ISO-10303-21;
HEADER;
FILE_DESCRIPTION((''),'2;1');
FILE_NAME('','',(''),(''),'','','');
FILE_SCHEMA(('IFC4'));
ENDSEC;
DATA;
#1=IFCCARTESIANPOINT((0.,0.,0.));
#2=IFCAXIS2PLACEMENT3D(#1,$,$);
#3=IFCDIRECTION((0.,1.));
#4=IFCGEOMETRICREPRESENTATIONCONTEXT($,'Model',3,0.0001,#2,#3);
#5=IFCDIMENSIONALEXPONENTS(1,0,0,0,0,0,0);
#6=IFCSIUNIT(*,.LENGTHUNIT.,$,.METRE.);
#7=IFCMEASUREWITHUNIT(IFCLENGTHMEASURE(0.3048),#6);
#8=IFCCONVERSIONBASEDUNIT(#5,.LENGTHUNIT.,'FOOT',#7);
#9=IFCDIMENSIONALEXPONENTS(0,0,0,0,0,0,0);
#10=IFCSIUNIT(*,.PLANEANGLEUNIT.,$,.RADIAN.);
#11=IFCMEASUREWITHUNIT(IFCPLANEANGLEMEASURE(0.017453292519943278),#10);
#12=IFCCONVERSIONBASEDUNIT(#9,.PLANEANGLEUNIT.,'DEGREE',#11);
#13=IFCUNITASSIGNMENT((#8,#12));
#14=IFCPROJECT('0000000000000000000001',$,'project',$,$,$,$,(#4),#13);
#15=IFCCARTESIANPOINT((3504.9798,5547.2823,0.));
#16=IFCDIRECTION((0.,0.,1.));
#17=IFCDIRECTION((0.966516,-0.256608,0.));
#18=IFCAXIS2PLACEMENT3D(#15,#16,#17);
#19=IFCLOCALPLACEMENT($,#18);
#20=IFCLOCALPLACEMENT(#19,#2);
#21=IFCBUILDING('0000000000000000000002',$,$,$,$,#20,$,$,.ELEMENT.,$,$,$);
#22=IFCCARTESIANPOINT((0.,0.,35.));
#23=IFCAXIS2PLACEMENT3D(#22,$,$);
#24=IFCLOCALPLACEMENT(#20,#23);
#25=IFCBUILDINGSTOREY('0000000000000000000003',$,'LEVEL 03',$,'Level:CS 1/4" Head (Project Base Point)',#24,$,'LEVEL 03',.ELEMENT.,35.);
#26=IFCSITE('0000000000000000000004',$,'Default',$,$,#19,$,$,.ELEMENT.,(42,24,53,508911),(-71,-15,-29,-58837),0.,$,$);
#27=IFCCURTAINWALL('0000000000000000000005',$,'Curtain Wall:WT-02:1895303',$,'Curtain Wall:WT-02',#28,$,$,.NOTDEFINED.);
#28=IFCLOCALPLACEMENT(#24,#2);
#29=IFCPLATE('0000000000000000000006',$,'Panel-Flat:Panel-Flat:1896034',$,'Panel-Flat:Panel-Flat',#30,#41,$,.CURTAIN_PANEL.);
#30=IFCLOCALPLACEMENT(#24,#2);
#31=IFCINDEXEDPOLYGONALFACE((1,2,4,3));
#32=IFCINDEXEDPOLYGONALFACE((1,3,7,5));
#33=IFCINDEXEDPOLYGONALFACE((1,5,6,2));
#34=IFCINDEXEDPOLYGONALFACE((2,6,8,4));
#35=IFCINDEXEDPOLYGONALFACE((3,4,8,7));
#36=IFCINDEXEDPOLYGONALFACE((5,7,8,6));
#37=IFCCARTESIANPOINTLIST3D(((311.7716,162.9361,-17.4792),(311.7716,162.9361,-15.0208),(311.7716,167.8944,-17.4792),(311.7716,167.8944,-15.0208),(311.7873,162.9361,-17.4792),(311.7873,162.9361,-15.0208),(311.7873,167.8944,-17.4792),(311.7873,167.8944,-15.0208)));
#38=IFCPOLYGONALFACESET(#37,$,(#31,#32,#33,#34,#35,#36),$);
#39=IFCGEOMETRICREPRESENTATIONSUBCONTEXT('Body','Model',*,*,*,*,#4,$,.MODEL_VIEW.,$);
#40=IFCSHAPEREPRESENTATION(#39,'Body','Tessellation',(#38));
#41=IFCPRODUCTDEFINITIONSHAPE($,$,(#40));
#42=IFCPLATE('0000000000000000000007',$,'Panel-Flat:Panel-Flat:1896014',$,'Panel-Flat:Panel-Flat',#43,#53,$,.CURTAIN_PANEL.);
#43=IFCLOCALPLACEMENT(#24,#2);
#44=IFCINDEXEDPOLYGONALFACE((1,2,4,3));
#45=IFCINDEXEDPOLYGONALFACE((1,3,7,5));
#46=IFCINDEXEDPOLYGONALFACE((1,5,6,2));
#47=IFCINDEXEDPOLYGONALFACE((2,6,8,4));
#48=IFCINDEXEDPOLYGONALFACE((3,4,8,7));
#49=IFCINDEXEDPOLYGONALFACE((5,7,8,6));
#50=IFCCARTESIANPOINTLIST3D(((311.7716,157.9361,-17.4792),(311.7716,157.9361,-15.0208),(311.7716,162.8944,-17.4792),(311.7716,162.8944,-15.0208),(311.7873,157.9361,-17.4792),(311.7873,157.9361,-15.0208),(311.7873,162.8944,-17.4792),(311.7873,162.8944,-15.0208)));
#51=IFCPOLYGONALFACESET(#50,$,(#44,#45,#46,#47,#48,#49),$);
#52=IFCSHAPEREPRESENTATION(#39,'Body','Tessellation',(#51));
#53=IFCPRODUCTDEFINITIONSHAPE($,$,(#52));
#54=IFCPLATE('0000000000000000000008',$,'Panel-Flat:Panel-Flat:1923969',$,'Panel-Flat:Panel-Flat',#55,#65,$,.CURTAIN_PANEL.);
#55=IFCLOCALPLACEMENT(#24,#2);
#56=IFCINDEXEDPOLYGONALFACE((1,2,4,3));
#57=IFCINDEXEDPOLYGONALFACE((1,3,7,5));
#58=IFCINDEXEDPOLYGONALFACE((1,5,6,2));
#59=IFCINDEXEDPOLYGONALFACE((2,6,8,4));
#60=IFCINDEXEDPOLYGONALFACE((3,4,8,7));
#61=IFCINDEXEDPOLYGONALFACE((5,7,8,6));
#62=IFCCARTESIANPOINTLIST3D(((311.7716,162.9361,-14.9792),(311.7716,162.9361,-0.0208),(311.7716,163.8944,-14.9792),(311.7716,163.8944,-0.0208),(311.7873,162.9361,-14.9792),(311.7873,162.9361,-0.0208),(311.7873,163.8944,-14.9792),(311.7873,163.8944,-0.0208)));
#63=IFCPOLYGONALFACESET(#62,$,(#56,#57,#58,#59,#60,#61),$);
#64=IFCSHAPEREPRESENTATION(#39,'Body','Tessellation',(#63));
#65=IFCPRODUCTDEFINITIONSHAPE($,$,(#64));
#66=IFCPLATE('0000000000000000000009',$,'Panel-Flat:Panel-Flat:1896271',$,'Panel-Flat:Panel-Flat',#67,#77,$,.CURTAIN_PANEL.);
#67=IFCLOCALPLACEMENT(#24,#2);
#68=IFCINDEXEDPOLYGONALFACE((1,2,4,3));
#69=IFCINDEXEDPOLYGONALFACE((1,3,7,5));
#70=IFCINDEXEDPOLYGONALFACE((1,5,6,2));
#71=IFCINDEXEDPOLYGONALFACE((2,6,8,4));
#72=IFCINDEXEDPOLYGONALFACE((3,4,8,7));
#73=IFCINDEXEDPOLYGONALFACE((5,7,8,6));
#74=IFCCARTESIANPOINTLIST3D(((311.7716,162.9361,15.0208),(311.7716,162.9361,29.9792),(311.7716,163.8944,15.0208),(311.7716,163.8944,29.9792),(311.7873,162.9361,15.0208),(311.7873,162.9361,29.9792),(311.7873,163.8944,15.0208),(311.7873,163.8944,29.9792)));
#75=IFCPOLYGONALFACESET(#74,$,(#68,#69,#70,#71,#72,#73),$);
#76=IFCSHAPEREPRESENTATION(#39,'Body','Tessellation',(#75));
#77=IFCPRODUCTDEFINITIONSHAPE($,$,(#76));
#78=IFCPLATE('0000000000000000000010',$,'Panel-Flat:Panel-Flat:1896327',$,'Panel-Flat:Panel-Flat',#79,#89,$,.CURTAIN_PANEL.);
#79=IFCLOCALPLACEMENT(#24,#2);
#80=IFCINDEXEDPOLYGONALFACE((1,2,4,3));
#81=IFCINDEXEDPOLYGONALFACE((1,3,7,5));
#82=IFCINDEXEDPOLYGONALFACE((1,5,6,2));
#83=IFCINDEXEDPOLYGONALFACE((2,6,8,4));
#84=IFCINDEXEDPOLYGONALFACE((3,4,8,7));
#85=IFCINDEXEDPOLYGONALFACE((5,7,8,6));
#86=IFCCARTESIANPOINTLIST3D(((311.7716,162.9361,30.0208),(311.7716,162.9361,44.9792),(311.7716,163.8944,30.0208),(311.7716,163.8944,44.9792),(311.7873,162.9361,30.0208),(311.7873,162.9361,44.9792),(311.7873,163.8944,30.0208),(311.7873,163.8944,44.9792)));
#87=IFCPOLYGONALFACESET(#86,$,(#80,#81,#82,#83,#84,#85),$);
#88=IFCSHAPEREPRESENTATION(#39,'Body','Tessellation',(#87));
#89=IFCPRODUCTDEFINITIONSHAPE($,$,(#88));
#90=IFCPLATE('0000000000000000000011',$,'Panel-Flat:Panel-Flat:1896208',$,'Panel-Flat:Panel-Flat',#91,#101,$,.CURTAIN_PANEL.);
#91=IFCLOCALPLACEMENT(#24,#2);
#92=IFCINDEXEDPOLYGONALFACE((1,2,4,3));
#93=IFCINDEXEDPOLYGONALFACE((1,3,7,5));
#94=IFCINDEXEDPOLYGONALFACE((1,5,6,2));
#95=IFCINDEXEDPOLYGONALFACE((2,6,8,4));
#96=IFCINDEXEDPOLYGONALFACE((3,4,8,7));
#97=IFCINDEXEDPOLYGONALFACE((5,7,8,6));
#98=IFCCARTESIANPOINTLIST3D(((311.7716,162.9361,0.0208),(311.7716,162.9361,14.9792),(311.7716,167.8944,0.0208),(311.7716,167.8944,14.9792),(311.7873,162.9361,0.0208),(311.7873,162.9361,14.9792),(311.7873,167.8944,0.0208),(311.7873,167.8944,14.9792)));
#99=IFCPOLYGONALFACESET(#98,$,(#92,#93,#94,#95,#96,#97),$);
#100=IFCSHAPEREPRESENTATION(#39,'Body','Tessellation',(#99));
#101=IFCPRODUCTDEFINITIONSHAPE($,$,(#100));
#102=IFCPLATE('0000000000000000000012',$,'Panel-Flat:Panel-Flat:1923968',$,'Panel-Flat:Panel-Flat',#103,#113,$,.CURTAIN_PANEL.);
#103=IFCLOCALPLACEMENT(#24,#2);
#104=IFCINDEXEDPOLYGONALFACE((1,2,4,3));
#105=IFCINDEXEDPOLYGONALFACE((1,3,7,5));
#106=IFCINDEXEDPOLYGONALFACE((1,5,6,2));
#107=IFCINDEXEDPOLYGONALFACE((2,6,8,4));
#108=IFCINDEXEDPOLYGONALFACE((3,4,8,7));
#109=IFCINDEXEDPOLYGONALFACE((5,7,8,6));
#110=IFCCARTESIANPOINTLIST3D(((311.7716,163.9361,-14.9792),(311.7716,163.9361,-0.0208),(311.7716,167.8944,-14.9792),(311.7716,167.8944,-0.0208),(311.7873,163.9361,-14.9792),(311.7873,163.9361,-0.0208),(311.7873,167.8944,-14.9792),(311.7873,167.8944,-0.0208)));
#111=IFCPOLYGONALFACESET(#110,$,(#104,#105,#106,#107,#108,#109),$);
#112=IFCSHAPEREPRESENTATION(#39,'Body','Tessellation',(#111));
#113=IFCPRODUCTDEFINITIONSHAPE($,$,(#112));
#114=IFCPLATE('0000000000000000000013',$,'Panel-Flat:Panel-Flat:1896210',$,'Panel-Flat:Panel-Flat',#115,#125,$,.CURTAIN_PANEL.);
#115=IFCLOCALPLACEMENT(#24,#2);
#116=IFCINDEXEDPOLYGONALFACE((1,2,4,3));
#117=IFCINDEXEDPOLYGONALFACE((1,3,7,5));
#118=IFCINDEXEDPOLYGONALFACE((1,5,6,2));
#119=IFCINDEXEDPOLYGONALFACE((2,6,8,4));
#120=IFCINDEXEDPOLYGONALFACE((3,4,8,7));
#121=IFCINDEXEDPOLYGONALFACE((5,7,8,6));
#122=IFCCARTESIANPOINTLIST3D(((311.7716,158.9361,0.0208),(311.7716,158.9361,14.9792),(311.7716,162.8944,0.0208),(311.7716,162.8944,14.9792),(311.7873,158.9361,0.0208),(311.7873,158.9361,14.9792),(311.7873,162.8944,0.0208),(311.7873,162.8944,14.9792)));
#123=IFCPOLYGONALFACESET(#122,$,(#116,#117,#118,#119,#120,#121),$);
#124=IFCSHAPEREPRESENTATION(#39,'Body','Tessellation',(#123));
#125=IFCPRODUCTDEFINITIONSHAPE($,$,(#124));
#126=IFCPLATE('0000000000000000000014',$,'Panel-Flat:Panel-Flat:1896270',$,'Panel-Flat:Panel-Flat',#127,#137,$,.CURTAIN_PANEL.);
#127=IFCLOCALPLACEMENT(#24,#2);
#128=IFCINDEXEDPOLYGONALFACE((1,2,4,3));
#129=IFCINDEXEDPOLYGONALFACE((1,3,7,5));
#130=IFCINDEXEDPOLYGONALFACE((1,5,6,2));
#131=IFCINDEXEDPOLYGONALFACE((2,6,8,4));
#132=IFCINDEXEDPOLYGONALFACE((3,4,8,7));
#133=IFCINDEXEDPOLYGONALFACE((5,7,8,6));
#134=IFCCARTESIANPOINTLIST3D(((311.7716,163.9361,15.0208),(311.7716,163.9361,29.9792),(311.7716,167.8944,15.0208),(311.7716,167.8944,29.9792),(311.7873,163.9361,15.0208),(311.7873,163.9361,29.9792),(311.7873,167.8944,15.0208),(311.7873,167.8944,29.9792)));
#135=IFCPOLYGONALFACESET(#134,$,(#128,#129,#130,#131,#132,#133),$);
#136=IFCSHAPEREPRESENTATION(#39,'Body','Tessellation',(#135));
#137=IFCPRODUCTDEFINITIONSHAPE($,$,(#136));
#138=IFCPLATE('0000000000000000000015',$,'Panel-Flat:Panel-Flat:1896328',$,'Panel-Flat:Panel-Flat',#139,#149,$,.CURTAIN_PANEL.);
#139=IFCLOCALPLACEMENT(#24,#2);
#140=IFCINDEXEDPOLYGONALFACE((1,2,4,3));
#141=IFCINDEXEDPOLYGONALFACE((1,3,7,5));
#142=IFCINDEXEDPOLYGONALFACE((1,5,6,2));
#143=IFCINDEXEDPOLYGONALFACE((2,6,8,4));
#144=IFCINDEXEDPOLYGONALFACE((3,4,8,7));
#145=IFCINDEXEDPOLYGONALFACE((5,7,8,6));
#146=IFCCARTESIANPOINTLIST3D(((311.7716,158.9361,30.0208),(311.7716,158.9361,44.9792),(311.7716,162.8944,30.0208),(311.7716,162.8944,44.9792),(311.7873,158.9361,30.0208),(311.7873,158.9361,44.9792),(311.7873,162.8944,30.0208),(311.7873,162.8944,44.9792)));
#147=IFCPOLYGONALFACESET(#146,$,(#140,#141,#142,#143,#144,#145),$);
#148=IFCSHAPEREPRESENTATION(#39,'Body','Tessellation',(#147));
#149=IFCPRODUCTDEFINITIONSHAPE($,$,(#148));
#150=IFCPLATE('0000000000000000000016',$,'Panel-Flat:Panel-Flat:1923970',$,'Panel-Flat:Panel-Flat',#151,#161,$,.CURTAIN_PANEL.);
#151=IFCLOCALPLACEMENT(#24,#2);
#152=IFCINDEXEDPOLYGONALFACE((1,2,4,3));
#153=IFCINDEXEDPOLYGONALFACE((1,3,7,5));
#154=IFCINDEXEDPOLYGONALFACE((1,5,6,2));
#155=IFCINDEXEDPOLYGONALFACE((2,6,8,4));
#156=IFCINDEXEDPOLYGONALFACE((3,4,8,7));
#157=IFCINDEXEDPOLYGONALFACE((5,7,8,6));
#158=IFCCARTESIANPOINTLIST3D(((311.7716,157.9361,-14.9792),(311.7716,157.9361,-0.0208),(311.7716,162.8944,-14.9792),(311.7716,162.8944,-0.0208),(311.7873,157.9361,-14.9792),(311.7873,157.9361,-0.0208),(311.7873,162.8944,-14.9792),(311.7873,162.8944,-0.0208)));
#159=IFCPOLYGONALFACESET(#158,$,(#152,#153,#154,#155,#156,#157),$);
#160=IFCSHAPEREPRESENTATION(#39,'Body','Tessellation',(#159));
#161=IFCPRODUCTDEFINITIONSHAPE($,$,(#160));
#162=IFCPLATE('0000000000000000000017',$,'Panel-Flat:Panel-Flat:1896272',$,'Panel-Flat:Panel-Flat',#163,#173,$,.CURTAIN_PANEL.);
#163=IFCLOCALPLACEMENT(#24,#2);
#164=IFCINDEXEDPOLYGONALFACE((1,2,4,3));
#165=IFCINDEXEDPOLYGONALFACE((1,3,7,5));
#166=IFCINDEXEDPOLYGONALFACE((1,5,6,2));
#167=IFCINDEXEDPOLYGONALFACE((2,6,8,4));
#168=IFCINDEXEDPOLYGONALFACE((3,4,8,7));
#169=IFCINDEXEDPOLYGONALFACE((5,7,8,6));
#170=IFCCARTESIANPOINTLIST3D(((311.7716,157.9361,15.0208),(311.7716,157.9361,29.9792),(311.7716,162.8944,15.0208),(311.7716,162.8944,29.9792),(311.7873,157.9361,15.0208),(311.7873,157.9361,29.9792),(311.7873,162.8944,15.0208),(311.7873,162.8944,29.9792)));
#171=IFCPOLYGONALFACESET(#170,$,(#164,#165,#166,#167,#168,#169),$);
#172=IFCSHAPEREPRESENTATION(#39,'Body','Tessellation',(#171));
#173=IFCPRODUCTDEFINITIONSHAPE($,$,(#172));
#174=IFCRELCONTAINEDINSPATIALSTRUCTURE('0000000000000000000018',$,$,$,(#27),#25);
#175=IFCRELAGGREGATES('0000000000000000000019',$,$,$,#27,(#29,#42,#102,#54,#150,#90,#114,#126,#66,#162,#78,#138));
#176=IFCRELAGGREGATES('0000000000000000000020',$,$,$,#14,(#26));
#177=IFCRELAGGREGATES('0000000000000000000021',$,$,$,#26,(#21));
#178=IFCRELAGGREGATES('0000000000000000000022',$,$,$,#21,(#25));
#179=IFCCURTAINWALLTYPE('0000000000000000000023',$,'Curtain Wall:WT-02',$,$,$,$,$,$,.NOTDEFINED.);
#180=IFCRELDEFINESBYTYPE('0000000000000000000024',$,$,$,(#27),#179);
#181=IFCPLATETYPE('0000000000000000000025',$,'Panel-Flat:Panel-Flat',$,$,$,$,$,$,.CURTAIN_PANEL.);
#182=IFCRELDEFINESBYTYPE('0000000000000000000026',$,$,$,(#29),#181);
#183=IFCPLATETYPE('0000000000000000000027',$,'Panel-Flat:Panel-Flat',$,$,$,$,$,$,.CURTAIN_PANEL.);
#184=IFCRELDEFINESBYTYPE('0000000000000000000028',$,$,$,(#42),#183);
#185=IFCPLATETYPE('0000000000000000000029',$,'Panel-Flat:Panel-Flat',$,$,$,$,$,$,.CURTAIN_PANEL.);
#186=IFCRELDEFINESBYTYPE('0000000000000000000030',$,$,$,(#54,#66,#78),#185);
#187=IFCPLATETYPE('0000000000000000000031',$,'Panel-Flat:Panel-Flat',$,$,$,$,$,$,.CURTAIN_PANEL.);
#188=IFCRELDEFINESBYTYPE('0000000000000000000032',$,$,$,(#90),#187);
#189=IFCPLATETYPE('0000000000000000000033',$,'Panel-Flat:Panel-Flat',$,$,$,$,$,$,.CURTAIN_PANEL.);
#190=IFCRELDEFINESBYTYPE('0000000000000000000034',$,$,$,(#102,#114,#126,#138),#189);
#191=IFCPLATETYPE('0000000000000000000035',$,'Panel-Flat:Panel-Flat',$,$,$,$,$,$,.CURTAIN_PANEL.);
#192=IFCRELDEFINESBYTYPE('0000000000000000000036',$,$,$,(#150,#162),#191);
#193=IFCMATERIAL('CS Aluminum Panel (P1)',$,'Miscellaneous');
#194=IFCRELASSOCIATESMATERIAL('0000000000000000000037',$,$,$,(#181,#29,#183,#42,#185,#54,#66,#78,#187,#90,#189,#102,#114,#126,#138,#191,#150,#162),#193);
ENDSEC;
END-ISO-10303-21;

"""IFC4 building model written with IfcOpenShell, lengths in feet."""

from ifc_helpers import new_model, entity, si_unit, converted_unit, direction, frame, origin, place, context, subcontext, project, spatial, indexed_curve, outline, extrude, source, transform, mapped, material, type_object, type_shapes, element, aggregate, save


model = new_model("IFC4")

# Units and contexts
model_context = context("Model", 3, precision=0.0001, world=origin(), true_north=direction((0.0, 1.0)))
body_context = subcontext(model_context, "Body", "Model", "MODEL_VIEW")
ifc_project = project(units=[converted_unit("LENGTHUNIT", "FOOT", entity("IfcLengthMeasure", 0.3048), si_unit("LENGTHUNIT", "METRE"), dimensions=[1, 0, 0, 0, 0, 0, 0]), converted_unit("PLANEANGLEUNIT", "DEGREE", entity("IfcPlaneAngleMeasure", 0.017453292519943278), si_unit("PLANEANGLEUNIT", "RADIAN"), dimensions=[0, 0, 0, 0, 0, 0, 0])], contexts=[model_context])

# Site, building, storey
site_placement = place(None, frame((3504.9798, 5547.2823, 0.0), z_axis=(0.0, 0.0, 1.0), x_axis=(0.966516, -0.256608, 0.0)))
site = spatial("IfcSite", under=ifc_project, at=site_placement, Name="Default", CompositionType="ELEMENT", RefLatitude=(42, 24, 53, 508911), RefLongitude=(-71, -15, -29, -58837), RefElevation=0.0)
building_placement = place(site_placement, origin())
building = spatial("IfcBuilding", under=site, at=building_placement, CompositionType="ELEMENT")
storey_placement = place(building_placement, frame((0.0, 0.0, 35.0)))
storey = spatial("IfcBuildingStorey", under=building, at=storey_placement, Name="LEVEL 03", ObjectType="Level:CS 1/4\" Head (Project Base Point)", LongName="LEVEL 03", CompositionType="ELEMENT", Elevation=35.0)

# Curtain wall, plates
curtain_wall_type = type_object("IfcCurtainWallType", Name="Curtain Wall:WT-02", PredefinedType="NOTDEFINED")
curtain_wall_placement = place(storey_placement, frame((0.0, 0.0, -35.0)))
curtain_wall = element("IfcCurtainWall", 1, at=curtain_wall_placement, inside=storey, type_object=curtain_wall_type, Name="Curtain Wall:WT-02:1895303", ObjectType="Curtain Wall:WT-02", PredefinedType="NOTDEFINED")
ifc_material_1 = material(Name="CS Aluminum Panel (P1)", Category="Miscellaneous")
plate_type_1 = type_object("IfcPlateType", Name="Panel-Flat:Panel-Flat", PredefinedType="CURTAIN_PANEL", material=ifc_material_1)
shared_shape_1 = source(origin(), body_context, "Body", "SweptSolid", [
    extrude(outline(indexed_curve([(-0.0078, -2.4792), (0.0078, -2.4792), (0.0078, 2.4792), (-0.0078, 2.4792), (-0.0078, -2.4792)], self_intersect=False)), frame((0.0, -0.0078, 0.0208), z_axis=(0.0, 0.0, 1.0), x_axis=(0.0, -1.0, 0.0)), (0.0, 0.0, 1.0), 2.4583),
])
type_shapes(plate_type_1, [shared_shape_1])
plate_1_placement = place(curtain_wall_placement, frame((311.7873, 165.4153, 17.5), z_axis=(0.0, 0.0, 1.0), x_axis=(0.0, -1.0, 0.0)))
plate_1 = element("IfcPlate", 2, at=plate_1_placement, type_object=plate_type_1, material=ifc_material_1, Name="Panel-Flat:Panel-Flat:1896034", ObjectType="Panel-Flat:Panel-Flat", PredefinedType="CURTAIN_PANEL", context=body_context, shape_type="MappedRepresentation", body=[
    mapped(shared_shape_1, transform((0.0, 0.0, 0.0), scale=1.0)),
])
plate_type_2 = type_object("IfcPlateType", Name="Panel-Flat:Panel-Flat", PredefinedType="CURTAIN_PANEL", material=ifc_material_1)
shared_shape_2 = source(origin(), body_context, "Body", "SweptSolid", [
    extrude(outline(indexed_curve([(-0.0078, -2.4792), (0.0078, -2.4792), (0.0078, 2.4792), (-0.0078, 2.4792), (-0.0078, -2.4792)], self_intersect=False)), frame((0.0, -0.0078, 0.0208), z_axis=(0.0, 0.0, 1.0), x_axis=(0.0, -1.0, 0.0)), (0.0, 0.0, 1.0), 2.4583),
])
type_shapes(plate_type_2, [shared_shape_2])
plate_2_placement = place(curtain_wall_placement, frame((311.7873, 160.4153, 17.5), z_axis=(0.0, 0.0, 1.0), x_axis=(0.0, -1.0, 0.0)))
plate_2 = element("IfcPlate", 3, at=plate_2_placement, type_object=plate_type_2, material=ifc_material_1, Name="Panel-Flat:Panel-Flat:1896014", ObjectType="Panel-Flat:Panel-Flat", PredefinedType="CURTAIN_PANEL", context=body_context, shape_type="MappedRepresentation", body=[
    mapped(shared_shape_2, transform((0.0, 0.0, 0.0), scale=1.0)),
])
plate_type_3 = type_object("IfcPlateType", Name="Panel-Flat:Panel-Flat", PredefinedType="CURTAIN_PANEL", material=ifc_material_1)
shared_shape_3 = source(origin(), body_context, "Body", "SweptSolid", [
    extrude(outline(indexed_curve([(-0.0078, -0.4792), (0.0078, -0.4792), (0.0078, 0.4792), (-0.0078, 0.4792), (-0.0078, -0.4792)], self_intersect=False)), frame((0.0, -0.0078, 0.0208), z_axis=(0.0, 0.0, 1.0), x_axis=(0.0, -1.0, 0.0)), (0.0, 0.0, 1.0), 14.9583),
])
type_shapes(plate_type_3, [shared_shape_3])
plate_3_placement = place(curtain_wall_placement, frame((311.7873, 163.4153, 20.0), z_axis=(0.0, 0.0, 1.0), x_axis=(0.0, -1.0, 0.0)))
plate_3 = element("IfcPlate", 4, at=plate_3_placement, type_object=plate_type_3, material=ifc_material_1, Name="Panel-Flat:Panel-Flat:1923969", ObjectType="Panel-Flat:Panel-Flat", PredefinedType="CURTAIN_PANEL", context=body_context, shape_type="MappedRepresentation", body=[
    mapped(shared_shape_3, transform((0.0, 0.0, 0.0), scale=1.0)),
])
plate_4_placement = place(curtain_wall_placement, frame((311.7873, 163.4153, 50.0), z_axis=(0.0, 0.0, 1.0), x_axis=(0.0, -1.0, 0.0)))
plate_4 = element("IfcPlate", 5, at=plate_4_placement, type_object=plate_type_3, material=ifc_material_1, Name="Panel-Flat:Panel-Flat:1896271", ObjectType="Panel-Flat:Panel-Flat", PredefinedType="CURTAIN_PANEL", context=body_context, shape_type="MappedRepresentation", body=[
    mapped(shared_shape_3, transform((0.0, 0.0, 0.0), scale=1.0)),
])
plate_5_placement = place(curtain_wall_placement, frame((311.7873, 163.4153, 65.0), z_axis=(0.0, 0.0, 1.0), x_axis=(0.0, -1.0, 0.0)))
plate_5 = element("IfcPlate", 6, at=plate_5_placement, type_object=plate_type_3, material=ifc_material_1, Name="Panel-Flat:Panel-Flat:1896327", ObjectType="Panel-Flat:Panel-Flat", PredefinedType="CURTAIN_PANEL", context=body_context, shape_type="MappedRepresentation", body=[
    mapped(shared_shape_3, transform((0.0, 0.0, 0.0), scale=1.0)),
])
plate_type_4 = type_object("IfcPlateType", Name="Panel-Flat:Panel-Flat", PredefinedType="CURTAIN_PANEL", material=ifc_material_1)
shared_shape_4 = source(origin(), body_context, "Body", "SweptSolid", [
    extrude(outline(indexed_curve([(-0.0078, -2.4792), (0.0078, -2.4792), (0.0078, 2.4792), (-0.0078, 2.4792), (-0.0078, -2.4792)], self_intersect=False)), frame((0.0, -0.0078, 0.0208), z_axis=(0.0, 0.0, 1.0), x_axis=(0.0, -1.0, 0.0)), (0.0, 0.0, 1.0), 14.9583),
])
type_shapes(plate_type_4, [shared_shape_4])
plate_6_placement = place(curtain_wall_placement, frame((311.7873, 165.4153, 35.0), z_axis=(0.0, 0.0, 1.0), x_axis=(0.0, -1.0, 0.0)))
plate_6 = element("IfcPlate", 7, at=plate_6_placement, type_object=plate_type_4, material=ifc_material_1, Name="Panel-Flat:Panel-Flat:1896208", ObjectType="Panel-Flat:Panel-Flat", PredefinedType="CURTAIN_PANEL", context=body_context, shape_type="MappedRepresentation", body=[
    mapped(shared_shape_4, transform((0.0, 0.0, 0.0), scale=1.0)),
])
plate_type_5 = type_object("IfcPlateType", Name="Panel-Flat:Panel-Flat", PredefinedType="CURTAIN_PANEL", material=ifc_material_1)
shared_shape_5 = source(origin(), body_context, "Body", "SweptSolid", [
    extrude(outline(indexed_curve([(-0.0078, -1.9792), (0.0078, -1.9792), (0.0078, 1.9792), (-0.0078, 1.9792), (-0.0078, -1.9792)], self_intersect=False)), frame((0.0, -0.0078, 0.0208), z_axis=(0.0, 0.0, 1.0), x_axis=(0.0, -1.0, 0.0)), (0.0, 0.0, 1.0), 14.9583),
])
type_shapes(plate_type_5, [shared_shape_5])
plate_7_placement = place(curtain_wall_placement, frame((311.7873, 165.9153, 20.0), z_axis=(0.0, 0.0, 1.0), x_axis=(0.0, -1.0, 0.0)))
plate_7 = element("IfcPlate", 8, at=plate_7_placement, type_object=plate_type_5, material=ifc_material_1, Name="Panel-Flat:Panel-Flat:1923968", ObjectType="Panel-Flat:Panel-Flat", PredefinedType="CURTAIN_PANEL", context=body_context, shape_type="MappedRepresentation", body=[
    mapped(shared_shape_5, transform((0.0, 0.0, 0.0), scale=1.0)),
])
plate_8_placement = place(curtain_wall_placement, frame((311.7873, 160.9153, 35.0), z_axis=(0.0, 0.0, 1.0), x_axis=(0.0, -1.0, 0.0)))
plate_8 = element("IfcPlate", 9, at=plate_8_placement, type_object=plate_type_5, material=ifc_material_1, Name="Panel-Flat:Panel-Flat:1896210", ObjectType="Panel-Flat:Panel-Flat", PredefinedType="CURTAIN_PANEL", context=body_context, shape_type="MappedRepresentation", body=[
    mapped(shared_shape_5, transform((0.0, 0.0, 0.0), scale=1.0)),
])
plate_9_placement = place(curtain_wall_placement, frame((311.7873, 165.9153, 50.0), z_axis=(0.0, 0.0, 1.0), x_axis=(0.0, -1.0, 0.0)))
plate_9 = element("IfcPlate", 10, at=plate_9_placement, type_object=plate_type_5, material=ifc_material_1, Name="Panel-Flat:Panel-Flat:1896270", ObjectType="Panel-Flat:Panel-Flat", PredefinedType="CURTAIN_PANEL", context=body_context, shape_type="MappedRepresentation", body=[
    mapped(shared_shape_5, transform((0.0, 0.0, 0.0), scale=1.0)),
])
plate_10_placement = place(curtain_wall_placement, frame((311.7873, 160.9153, 65.0), z_axis=(0.0, 0.0, 1.0), x_axis=(0.0, -1.0, 0.0)))
plate_10 = element("IfcPlate", 11, at=plate_10_placement, type_object=plate_type_5, material=ifc_material_1, Name="Panel-Flat:Panel-Flat:1896328", ObjectType="Panel-Flat:Panel-Flat", PredefinedType="CURTAIN_PANEL", context=body_context, shape_type="MappedRepresentation", body=[
    mapped(shared_shape_5, transform((0.0, 0.0, 0.0), scale=1.0)),
])
plate_type_6 = type_object("IfcPlateType", Name="Panel-Flat:Panel-Flat", PredefinedType="CURTAIN_PANEL", material=ifc_material_1)
shared_shape_6 = source(origin(), body_context, "Body", "SweptSolid", [
    extrude(outline(indexed_curve([(-0.0078, -2.4792), (0.0078, -2.4792), (0.0078, 2.4792), (-0.0078, 2.4792), (-0.0078, -2.4792)], self_intersect=False)), frame((0.0, -0.0078, 0.0208), z_axis=(0.0, 0.0, 1.0), x_axis=(0.0, -1.0, 0.0)), (0.0, 0.0, 1.0), 14.9583),
])
type_shapes(plate_type_6, [shared_shape_6])
plate_11_placement = place(curtain_wall_placement, frame((311.7873, 160.4153, 20.0), z_axis=(0.0, 0.0, 1.0), x_axis=(0.0, -1.0, 0.0)))
plate_11 = element("IfcPlate", 12, at=plate_11_placement, type_object=plate_type_6, material=ifc_material_1, Name="Panel-Flat:Panel-Flat:1923970", ObjectType="Panel-Flat:Panel-Flat", PredefinedType="CURTAIN_PANEL", context=body_context, shape_type="MappedRepresentation", body=[
    mapped(shared_shape_6, transform((0.0, 0.0, 0.0), scale=1.0)),
])
plate_12_placement = place(curtain_wall_placement, frame((311.7873, 160.4153, 50.0), z_axis=(0.0, 0.0, 1.0), x_axis=(0.0, -1.0, 0.0)))
plate_12 = element("IfcPlate", 13, at=plate_12_placement, type_object=plate_type_6, material=ifc_material_1, Name="Panel-Flat:Panel-Flat:1896272", ObjectType="Panel-Flat:Panel-Flat", PredefinedType="CURTAIN_PANEL", context=body_context, shape_type="MappedRepresentation", body=[
    mapped(shared_shape_6, transform((0.0, 0.0, 0.0), scale=1.0)),
])
aggregate(curtain_wall, [plate_1, plate_2, plate_7, plate_3, plate_11, plate_6, plate_8, plate_9, plate_4, plate_12, plate_5, plate_10])

save(model, "model.ifc")
